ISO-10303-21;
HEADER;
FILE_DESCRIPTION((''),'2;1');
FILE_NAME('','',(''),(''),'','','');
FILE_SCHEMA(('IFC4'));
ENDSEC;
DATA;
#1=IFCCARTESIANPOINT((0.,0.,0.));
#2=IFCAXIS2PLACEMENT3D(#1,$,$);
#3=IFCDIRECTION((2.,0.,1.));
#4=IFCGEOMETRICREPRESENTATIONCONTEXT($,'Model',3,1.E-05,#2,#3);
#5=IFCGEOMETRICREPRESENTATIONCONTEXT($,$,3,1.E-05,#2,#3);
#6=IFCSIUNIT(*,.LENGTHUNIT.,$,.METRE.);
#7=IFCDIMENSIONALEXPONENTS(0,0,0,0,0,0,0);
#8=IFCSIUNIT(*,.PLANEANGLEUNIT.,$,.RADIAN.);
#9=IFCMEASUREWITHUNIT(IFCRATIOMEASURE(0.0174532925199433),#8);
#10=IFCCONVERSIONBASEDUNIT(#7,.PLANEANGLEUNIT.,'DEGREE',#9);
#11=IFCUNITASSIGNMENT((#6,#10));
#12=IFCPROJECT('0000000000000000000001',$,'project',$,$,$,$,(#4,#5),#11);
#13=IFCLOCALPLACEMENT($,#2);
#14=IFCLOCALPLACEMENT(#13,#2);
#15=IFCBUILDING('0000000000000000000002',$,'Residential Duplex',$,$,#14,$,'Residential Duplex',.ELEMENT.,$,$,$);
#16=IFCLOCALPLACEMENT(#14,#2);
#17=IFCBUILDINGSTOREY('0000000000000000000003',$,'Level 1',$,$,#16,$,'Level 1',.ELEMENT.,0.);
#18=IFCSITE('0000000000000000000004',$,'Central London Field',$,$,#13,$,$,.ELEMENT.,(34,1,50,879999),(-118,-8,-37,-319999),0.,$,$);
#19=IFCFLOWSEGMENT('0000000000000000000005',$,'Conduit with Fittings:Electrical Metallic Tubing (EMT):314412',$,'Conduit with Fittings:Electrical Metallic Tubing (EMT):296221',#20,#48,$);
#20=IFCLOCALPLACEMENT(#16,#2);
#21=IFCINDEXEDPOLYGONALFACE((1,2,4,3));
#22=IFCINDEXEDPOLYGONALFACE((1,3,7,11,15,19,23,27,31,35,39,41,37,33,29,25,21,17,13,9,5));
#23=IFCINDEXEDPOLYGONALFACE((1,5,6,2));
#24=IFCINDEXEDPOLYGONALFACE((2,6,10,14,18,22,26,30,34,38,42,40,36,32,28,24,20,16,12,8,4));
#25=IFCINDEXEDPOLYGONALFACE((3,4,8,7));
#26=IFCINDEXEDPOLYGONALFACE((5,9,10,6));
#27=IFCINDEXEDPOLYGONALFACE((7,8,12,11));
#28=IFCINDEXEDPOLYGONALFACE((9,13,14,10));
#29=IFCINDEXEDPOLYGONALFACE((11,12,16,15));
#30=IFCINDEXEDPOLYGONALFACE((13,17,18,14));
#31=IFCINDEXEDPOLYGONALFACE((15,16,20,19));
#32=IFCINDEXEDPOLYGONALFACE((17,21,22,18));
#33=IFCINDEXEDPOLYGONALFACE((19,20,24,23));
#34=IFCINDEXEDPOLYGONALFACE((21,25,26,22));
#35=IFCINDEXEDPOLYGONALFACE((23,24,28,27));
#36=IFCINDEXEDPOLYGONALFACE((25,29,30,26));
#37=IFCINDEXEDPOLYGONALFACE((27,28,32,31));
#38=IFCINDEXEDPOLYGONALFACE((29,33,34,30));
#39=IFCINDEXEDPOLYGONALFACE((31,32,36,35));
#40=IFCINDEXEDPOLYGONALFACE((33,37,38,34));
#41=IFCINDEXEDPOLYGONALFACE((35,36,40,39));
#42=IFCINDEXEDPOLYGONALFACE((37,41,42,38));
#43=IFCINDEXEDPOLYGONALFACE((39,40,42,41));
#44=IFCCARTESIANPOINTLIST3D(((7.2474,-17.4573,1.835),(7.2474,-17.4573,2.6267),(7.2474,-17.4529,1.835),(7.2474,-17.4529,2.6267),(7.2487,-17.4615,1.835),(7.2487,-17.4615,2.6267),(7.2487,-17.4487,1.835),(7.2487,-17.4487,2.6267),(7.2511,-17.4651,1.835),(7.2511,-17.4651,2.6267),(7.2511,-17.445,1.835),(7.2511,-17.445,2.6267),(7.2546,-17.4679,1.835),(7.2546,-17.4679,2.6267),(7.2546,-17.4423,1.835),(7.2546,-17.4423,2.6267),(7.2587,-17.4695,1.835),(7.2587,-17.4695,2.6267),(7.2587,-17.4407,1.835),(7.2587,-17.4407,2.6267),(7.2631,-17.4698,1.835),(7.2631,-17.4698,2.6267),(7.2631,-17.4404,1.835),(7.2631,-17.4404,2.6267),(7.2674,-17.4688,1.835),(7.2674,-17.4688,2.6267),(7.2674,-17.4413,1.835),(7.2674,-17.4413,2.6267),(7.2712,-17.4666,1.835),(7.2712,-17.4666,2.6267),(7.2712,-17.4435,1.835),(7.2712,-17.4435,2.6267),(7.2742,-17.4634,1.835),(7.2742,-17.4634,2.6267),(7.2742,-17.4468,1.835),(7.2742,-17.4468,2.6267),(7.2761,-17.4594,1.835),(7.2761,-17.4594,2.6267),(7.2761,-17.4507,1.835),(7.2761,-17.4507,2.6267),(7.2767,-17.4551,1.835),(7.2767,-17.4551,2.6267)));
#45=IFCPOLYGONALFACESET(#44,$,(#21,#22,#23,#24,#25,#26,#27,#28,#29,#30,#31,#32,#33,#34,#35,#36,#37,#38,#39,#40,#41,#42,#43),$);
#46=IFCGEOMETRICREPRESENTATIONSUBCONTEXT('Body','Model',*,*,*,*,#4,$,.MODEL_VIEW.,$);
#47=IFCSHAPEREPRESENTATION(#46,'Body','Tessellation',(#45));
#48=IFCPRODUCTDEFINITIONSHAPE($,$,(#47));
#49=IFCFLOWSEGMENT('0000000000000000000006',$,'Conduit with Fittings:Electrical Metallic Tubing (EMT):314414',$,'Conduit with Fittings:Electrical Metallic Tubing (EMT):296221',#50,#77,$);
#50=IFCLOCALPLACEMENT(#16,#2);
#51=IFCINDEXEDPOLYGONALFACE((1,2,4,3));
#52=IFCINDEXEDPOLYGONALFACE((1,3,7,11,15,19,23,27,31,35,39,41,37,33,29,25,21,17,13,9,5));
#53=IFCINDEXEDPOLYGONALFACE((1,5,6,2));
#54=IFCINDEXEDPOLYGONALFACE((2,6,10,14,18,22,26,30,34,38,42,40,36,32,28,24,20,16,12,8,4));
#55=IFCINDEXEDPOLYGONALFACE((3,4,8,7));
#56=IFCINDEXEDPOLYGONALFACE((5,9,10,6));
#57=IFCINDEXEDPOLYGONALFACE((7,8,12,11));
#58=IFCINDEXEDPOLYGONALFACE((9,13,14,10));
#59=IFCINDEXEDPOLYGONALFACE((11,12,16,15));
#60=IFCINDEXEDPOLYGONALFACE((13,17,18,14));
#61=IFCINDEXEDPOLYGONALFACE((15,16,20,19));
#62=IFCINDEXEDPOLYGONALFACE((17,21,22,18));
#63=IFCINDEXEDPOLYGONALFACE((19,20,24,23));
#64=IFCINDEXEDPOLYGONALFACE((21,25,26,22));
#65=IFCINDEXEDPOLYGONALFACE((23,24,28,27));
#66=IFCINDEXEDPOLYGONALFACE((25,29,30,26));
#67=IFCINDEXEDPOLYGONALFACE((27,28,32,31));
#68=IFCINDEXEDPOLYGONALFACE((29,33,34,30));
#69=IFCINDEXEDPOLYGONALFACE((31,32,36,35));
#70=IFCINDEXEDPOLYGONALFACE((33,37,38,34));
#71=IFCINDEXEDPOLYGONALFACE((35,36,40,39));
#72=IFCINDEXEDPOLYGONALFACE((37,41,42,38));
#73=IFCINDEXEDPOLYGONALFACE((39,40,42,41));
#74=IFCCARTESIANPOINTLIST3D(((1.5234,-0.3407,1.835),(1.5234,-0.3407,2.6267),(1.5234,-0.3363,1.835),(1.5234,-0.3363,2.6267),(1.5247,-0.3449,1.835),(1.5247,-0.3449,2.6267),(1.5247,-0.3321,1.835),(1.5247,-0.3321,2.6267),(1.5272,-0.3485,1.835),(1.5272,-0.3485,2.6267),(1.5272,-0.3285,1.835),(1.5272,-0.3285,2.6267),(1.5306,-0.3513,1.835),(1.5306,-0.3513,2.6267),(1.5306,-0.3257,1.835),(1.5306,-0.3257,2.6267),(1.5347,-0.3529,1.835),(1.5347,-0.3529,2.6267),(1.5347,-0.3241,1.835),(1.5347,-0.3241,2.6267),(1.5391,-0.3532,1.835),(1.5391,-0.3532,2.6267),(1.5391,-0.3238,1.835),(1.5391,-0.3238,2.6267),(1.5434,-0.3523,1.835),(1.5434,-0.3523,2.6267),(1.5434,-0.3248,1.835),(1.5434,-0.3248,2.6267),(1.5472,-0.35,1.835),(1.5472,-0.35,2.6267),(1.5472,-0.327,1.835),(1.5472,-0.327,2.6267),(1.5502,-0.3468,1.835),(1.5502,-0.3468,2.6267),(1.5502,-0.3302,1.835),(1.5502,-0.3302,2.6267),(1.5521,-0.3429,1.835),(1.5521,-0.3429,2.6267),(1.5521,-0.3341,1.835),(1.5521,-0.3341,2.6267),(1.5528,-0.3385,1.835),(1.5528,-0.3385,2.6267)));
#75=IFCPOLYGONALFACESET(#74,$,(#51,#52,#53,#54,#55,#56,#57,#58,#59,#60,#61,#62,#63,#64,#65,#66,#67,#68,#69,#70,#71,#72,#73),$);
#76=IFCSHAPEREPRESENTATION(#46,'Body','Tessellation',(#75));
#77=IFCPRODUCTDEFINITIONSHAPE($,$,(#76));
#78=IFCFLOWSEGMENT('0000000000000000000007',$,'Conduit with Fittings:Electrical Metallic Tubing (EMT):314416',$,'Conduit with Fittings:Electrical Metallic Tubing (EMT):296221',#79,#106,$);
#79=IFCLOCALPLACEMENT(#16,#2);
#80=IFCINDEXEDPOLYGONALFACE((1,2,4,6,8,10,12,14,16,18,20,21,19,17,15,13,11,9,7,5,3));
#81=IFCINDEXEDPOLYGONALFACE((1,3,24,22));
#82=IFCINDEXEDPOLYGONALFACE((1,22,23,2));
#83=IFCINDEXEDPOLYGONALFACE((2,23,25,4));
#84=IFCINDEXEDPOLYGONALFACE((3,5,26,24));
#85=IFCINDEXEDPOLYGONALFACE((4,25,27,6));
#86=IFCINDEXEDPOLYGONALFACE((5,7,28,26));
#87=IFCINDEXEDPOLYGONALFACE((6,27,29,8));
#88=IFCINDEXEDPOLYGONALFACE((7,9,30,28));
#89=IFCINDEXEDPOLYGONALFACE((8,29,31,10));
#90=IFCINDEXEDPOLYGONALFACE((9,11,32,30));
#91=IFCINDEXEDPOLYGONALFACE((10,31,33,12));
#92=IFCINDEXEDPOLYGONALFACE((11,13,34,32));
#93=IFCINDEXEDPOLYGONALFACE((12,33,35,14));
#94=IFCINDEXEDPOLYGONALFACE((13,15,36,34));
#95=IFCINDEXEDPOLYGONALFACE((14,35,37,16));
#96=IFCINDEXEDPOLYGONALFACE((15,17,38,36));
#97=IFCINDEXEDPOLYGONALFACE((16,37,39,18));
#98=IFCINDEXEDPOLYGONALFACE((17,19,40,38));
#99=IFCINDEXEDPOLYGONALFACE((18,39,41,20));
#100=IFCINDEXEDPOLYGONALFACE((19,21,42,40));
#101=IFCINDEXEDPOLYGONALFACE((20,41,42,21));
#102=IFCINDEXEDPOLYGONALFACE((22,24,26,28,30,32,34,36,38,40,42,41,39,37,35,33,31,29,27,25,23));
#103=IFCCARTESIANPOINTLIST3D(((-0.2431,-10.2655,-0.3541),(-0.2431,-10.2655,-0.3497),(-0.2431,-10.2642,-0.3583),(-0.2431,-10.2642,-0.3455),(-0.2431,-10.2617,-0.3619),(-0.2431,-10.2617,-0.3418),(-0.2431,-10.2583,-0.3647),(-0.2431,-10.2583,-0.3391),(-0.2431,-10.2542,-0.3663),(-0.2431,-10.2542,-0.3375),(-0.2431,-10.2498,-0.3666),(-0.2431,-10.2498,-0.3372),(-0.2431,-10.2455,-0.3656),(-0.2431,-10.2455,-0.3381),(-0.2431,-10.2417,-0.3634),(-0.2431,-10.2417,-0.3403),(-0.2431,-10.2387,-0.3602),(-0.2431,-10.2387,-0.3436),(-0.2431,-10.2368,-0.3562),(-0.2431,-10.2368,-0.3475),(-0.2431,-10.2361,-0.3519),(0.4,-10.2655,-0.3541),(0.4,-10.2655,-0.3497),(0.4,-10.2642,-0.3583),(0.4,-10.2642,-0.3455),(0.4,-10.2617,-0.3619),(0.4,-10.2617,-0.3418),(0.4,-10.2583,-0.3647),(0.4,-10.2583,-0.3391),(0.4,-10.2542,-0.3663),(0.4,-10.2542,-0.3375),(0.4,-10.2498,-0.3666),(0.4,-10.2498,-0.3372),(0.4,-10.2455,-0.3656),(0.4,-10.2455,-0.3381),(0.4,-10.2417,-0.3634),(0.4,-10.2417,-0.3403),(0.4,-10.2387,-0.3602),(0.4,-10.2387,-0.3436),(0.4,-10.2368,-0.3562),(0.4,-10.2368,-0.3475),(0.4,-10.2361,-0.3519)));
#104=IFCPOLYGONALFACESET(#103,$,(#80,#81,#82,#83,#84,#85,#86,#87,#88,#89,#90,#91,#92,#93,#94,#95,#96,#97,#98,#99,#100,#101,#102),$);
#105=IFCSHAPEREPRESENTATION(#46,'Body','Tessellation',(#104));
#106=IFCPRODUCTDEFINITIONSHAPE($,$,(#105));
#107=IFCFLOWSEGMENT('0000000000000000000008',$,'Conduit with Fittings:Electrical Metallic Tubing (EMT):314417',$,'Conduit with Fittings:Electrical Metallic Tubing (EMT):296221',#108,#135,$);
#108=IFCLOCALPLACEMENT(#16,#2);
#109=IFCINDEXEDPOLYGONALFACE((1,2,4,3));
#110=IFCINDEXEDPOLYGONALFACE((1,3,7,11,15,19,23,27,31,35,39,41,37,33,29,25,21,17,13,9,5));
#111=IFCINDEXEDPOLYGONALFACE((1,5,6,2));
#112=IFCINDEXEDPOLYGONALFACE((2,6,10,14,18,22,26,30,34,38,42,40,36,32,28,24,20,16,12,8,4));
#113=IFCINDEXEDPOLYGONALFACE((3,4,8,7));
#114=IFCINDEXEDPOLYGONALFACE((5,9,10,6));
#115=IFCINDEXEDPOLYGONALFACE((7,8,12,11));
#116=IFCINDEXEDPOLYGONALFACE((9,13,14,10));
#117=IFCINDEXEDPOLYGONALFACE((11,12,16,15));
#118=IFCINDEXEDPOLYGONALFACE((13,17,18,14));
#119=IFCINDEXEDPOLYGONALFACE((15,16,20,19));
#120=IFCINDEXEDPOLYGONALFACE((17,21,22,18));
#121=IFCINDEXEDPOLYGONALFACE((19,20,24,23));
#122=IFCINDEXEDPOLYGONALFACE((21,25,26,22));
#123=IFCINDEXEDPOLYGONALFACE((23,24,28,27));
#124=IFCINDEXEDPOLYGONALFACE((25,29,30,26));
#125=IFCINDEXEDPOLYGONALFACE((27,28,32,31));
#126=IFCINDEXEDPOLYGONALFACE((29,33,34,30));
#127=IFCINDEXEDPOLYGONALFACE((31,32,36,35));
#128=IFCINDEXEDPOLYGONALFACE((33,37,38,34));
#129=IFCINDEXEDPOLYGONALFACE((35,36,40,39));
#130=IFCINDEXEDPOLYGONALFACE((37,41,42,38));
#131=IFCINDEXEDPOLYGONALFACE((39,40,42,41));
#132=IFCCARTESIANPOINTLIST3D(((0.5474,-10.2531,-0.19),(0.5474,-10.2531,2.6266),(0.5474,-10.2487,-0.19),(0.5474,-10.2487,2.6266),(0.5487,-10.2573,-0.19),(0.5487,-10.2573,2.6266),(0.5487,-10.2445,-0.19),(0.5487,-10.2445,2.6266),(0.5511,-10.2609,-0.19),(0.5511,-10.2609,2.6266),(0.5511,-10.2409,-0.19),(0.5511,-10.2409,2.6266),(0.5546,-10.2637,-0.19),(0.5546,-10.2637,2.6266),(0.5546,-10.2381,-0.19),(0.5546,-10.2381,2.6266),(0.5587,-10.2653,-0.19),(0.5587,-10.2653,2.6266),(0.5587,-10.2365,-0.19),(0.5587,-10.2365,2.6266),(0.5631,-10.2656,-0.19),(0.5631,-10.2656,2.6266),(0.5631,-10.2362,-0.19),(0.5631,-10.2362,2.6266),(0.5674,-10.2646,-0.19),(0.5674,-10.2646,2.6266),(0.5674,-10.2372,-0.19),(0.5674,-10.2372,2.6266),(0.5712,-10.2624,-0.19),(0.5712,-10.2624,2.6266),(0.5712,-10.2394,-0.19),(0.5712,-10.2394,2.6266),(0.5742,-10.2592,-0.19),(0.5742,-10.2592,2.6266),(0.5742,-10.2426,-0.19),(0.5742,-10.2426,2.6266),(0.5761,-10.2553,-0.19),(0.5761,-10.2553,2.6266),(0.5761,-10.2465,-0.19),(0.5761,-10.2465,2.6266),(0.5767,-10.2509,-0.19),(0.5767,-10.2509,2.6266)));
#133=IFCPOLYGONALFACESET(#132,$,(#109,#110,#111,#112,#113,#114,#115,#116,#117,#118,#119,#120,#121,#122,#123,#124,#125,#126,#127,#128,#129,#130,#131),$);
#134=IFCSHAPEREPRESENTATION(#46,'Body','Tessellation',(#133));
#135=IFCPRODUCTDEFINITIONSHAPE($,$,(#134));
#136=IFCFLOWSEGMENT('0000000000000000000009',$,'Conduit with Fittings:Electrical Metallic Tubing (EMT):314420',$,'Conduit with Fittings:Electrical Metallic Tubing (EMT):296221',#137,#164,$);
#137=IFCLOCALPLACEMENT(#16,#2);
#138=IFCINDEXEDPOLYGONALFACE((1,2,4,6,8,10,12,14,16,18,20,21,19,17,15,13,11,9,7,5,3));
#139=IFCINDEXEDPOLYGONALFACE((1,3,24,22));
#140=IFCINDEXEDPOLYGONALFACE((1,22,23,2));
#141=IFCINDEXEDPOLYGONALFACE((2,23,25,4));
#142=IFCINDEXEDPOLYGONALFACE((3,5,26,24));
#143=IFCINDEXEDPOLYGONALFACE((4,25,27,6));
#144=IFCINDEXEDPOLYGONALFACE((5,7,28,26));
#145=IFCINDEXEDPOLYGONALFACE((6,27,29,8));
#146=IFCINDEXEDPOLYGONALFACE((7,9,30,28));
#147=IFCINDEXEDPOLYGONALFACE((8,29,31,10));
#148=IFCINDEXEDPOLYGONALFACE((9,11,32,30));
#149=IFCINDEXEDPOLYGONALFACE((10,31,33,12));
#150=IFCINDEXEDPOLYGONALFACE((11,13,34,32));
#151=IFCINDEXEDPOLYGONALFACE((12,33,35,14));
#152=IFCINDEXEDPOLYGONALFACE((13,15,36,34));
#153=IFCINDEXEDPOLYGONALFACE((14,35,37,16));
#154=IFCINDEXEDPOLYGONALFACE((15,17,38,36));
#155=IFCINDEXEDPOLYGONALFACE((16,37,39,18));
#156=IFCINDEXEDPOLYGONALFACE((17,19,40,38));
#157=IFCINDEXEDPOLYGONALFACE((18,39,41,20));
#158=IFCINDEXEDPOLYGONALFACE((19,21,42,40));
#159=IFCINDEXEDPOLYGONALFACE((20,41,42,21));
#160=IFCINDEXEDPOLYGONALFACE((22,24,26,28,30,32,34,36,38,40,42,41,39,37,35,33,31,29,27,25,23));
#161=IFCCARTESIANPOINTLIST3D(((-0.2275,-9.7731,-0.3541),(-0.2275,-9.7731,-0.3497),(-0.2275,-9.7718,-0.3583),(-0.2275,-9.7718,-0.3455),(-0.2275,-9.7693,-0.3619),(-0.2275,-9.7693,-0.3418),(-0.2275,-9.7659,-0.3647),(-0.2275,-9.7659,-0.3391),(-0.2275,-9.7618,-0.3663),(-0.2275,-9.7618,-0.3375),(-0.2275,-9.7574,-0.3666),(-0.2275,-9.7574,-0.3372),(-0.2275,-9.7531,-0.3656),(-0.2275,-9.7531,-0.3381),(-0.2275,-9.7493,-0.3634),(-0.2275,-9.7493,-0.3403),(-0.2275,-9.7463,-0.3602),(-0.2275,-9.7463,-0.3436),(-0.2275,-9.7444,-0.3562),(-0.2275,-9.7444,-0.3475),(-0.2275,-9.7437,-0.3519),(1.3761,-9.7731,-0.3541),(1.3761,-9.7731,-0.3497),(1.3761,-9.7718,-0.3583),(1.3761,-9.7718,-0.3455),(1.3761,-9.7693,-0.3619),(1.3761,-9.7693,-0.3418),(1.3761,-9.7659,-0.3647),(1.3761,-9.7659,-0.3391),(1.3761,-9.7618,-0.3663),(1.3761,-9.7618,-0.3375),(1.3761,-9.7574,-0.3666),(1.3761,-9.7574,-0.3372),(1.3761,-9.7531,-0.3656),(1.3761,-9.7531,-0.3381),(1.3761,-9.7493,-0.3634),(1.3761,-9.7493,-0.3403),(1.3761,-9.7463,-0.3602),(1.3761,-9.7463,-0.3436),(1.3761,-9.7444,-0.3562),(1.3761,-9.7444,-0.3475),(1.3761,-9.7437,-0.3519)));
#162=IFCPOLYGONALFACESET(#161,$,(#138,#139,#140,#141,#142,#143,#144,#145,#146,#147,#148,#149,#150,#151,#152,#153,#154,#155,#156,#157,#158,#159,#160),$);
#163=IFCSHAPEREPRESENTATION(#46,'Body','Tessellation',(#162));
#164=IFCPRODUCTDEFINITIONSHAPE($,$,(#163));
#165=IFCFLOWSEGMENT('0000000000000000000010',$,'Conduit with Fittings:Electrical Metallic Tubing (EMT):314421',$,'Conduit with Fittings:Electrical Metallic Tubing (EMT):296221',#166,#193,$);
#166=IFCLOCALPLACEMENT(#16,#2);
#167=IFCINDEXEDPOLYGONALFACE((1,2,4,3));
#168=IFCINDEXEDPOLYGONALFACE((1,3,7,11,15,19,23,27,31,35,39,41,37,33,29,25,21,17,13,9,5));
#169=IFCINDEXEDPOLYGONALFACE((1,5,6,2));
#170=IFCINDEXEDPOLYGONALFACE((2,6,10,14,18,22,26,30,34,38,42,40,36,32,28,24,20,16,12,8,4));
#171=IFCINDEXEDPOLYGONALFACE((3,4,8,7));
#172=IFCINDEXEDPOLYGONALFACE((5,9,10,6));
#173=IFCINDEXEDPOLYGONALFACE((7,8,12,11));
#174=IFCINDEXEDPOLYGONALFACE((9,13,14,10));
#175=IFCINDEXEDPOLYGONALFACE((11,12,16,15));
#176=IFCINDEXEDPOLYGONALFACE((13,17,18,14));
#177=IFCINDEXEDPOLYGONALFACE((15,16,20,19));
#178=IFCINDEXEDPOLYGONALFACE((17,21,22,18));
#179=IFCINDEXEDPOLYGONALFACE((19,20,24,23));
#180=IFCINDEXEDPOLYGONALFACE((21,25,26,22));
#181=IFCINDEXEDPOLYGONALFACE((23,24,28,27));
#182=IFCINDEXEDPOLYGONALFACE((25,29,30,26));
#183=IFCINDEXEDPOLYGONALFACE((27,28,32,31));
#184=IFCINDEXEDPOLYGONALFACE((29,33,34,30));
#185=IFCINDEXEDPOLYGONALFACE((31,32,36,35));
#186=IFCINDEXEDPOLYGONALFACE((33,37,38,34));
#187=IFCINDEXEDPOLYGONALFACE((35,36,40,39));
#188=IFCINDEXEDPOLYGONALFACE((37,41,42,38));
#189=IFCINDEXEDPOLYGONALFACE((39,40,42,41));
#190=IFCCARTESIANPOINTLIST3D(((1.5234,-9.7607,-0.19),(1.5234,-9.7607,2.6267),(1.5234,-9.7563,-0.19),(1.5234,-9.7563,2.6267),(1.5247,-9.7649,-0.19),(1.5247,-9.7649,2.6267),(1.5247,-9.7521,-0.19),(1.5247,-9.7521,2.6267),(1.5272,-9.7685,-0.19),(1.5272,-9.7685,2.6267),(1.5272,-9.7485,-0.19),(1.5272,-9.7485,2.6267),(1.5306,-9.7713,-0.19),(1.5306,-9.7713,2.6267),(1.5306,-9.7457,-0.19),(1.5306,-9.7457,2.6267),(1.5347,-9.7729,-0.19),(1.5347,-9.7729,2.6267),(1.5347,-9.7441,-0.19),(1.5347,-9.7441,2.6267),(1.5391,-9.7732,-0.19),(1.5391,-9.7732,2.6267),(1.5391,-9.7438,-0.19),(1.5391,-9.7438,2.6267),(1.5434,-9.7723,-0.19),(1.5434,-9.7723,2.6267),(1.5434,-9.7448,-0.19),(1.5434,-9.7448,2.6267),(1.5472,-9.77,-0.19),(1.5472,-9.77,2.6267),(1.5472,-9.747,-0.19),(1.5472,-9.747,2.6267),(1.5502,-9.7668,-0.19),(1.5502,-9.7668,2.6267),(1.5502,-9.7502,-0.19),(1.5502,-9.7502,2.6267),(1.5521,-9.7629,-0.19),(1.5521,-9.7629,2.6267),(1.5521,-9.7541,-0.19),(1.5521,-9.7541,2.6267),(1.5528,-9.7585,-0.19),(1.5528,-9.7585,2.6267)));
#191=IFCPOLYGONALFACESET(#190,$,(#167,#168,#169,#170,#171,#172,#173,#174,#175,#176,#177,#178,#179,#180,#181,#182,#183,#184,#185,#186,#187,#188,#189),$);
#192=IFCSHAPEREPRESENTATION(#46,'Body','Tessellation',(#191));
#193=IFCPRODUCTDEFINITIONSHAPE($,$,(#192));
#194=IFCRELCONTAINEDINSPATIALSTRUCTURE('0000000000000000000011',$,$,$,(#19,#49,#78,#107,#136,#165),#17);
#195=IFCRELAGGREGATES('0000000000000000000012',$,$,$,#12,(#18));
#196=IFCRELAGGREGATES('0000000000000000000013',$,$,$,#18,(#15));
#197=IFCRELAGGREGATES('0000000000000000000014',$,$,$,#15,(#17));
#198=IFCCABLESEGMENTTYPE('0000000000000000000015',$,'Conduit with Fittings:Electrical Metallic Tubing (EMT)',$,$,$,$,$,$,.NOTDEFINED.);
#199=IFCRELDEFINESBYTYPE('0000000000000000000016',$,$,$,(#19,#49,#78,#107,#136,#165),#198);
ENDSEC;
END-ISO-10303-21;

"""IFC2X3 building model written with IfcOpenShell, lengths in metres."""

from ifc_helpers import new_model, entity, si_unit, converted_unit, direction, frame, frame_2d, origin, place, context, subcontext, project, spatial, circle, extrude, type_object, element, save


model = new_model("IFC2X3")

# Units and contexts
model_context = context("Model", 3, precision=1e-05, world=origin(), true_north=direction((2.0, 0.0, 1.0)))
context_of_model = context(None, 3, precision=1e-05, world=origin(), true_north=direction((2.0, 0.0, 1.0)))
body_context = subcontext(model_context, "Body", "Model", "MODEL_VIEW")
ifc_project = project(units=[si_unit("LENGTHUNIT", "METRE"), converted_unit("PLANEANGLEUNIT", "DEGREE", entity("IfcRatioMeasure", 0.0174532925199433), si_unit("PLANEANGLEUNIT", "RADIAN"), dimensions=[0, 0, 0, 0, 0, 0, 0])], contexts=[model_context, context_of_model])

# Site, building, storey
site_placement = place(None, origin())
site = spatial("IfcSite", under=ifc_project, at=site_placement, Name="Central London Field", CompositionType="ELEMENT", RefLatitude=(34, 1, 50, 879999), RefLongitude=(-118, -8, -37, -319999), RefElevation=0.0)
building_placement = place(site_placement, origin())
building = spatial("IfcBuilding", under=site, at=building_placement, Name="Residential Duplex", LongName="Residential Duplex", CompositionType="ELEMENT")
storey_placement = place(building_placement, origin())
storey = spatial("IfcBuildingStorey", under=building, at=storey_placement, Name="Level 1", LongName="Level 1", CompositionType="ELEMENT", Elevation=0.0)

# Flow segments
cable_segment_type = type_object("IfcCableSegmentType", Name="Conduit with Fittings:Electrical Metallic Tubing (EMT)", PredefinedType="NOTDEFINED")
flow_segment_1_placement = place(storey_placement, origin())
element("IfcFlowSegment", 1, at=flow_segment_1_placement, inside=storey, type_object=cable_segment_type, Name="Conduit with Fittings:Electrical Metallic Tubing (EMT):314412", ObjectType="Conduit with Fittings:Electrical Metallic Tubing (EMT):296221", context=body_context, shape_type="SweptSolid", body=[
    extrude(circle(Radius=0.0148, at=frame_2d((0.0, 0.0), x_axis=(1.0, 0.0))), frame((7.262, -17.4551, 1.835)), (0.0, 0.0, 1.0), 0.7917),
])
flow_segment_2_placement = place(storey_placement, origin())
element("IfcFlowSegment", 2, at=flow_segment_2_placement, inside=storey, type_object=cable_segment_type, Name="Conduit with Fittings:Electrical Metallic Tubing (EMT):314414", ObjectType="Conduit with Fittings:Electrical Metallic Tubing (EMT):296221", context=body_context, shape_type="SweptSolid", body=[
    extrude(circle(Radius=0.0148, at=frame_2d((0.0, 0.0), x_axis=(1.0, 0.0))), frame((1.538, -0.3385, 1.835)), (0.0, 0.0, 1.0), 0.7917),
])
flow_segment_3_placement = place(storey_placement, origin())
element("IfcFlowSegment", 3, at=flow_segment_3_placement, inside=storey, type_object=cable_segment_type, Name="Conduit with Fittings:Electrical Metallic Tubing (EMT):314416", ObjectType="Conduit with Fittings:Electrical Metallic Tubing (EMT):296221", context=body_context, shape_type="SweptSolid", body=[
    extrude(circle(Radius=0.0148, at=frame_2d((0.0, 0.0), x_axis=(1.0, 0.0))), frame((-0.2431, -10.2509, -0.3519), z_axis=(1.0, 0.0, 0.0), x_axis=(0.0, 1.0, 0.0)), (0.0, 0.0, 1.0), 0.6432),
])
flow_segment_4_placement = place(storey_placement, origin())
element("IfcFlowSegment", 4, at=flow_segment_4_placement, inside=storey, type_object=cable_segment_type, Name="Conduit with Fittings:Electrical Metallic Tubing (EMT):314417", ObjectType="Conduit with Fittings:Electrical Metallic Tubing (EMT):296221", context=body_context, shape_type="SweptSolid", body=[
    extrude(circle(Radius=0.0148, at=frame_2d((0.0, 0.0), x_axis=(1.0, 0.0))), frame((0.562, -10.2509, -0.19)), (0.0, 0.0, 1.0), 2.8166),
])
flow_segment_5_placement = place(storey_placement, origin())
element("IfcFlowSegment", 5, at=flow_segment_5_placement, inside=storey, type_object=cable_segment_type, Name="Conduit with Fittings:Electrical Metallic Tubing (EMT):314420", ObjectType="Conduit with Fittings:Electrical Metallic Tubing (EMT):296221", context=body_context, shape_type="SweptSolid", body=[
    extrude(circle(Radius=0.0148, at=frame_2d((0.0, 0.0), x_axis=(1.0, 0.0))), frame((-0.2275, -9.7585, -0.3519), z_axis=(1.0, 0.0, 0.0), x_axis=(0.0, 1.0, 0.0)), (0.0, 0.0, 1.0), 1.6036),
])
flow_segment_6_placement = place(storey_placement, origin())
element("IfcFlowSegment", 6, at=flow_segment_6_placement, inside=storey, type_object=cable_segment_type, Name="Conduit with Fittings:Electrical Metallic Tubing (EMT):314421", ObjectType="Conduit with Fittings:Electrical Metallic Tubing (EMT):296221", context=body_context, shape_type="SweptSolid", body=[
    extrude(circle(Radius=0.0148, at=frame_2d((0.0, 0.0), x_axis=(1.0, 0.0))), frame((1.538, -9.7585, -0.19)), (0.0, 0.0, 1.0), 2.8166),
])

save(model, "model.ifc")
